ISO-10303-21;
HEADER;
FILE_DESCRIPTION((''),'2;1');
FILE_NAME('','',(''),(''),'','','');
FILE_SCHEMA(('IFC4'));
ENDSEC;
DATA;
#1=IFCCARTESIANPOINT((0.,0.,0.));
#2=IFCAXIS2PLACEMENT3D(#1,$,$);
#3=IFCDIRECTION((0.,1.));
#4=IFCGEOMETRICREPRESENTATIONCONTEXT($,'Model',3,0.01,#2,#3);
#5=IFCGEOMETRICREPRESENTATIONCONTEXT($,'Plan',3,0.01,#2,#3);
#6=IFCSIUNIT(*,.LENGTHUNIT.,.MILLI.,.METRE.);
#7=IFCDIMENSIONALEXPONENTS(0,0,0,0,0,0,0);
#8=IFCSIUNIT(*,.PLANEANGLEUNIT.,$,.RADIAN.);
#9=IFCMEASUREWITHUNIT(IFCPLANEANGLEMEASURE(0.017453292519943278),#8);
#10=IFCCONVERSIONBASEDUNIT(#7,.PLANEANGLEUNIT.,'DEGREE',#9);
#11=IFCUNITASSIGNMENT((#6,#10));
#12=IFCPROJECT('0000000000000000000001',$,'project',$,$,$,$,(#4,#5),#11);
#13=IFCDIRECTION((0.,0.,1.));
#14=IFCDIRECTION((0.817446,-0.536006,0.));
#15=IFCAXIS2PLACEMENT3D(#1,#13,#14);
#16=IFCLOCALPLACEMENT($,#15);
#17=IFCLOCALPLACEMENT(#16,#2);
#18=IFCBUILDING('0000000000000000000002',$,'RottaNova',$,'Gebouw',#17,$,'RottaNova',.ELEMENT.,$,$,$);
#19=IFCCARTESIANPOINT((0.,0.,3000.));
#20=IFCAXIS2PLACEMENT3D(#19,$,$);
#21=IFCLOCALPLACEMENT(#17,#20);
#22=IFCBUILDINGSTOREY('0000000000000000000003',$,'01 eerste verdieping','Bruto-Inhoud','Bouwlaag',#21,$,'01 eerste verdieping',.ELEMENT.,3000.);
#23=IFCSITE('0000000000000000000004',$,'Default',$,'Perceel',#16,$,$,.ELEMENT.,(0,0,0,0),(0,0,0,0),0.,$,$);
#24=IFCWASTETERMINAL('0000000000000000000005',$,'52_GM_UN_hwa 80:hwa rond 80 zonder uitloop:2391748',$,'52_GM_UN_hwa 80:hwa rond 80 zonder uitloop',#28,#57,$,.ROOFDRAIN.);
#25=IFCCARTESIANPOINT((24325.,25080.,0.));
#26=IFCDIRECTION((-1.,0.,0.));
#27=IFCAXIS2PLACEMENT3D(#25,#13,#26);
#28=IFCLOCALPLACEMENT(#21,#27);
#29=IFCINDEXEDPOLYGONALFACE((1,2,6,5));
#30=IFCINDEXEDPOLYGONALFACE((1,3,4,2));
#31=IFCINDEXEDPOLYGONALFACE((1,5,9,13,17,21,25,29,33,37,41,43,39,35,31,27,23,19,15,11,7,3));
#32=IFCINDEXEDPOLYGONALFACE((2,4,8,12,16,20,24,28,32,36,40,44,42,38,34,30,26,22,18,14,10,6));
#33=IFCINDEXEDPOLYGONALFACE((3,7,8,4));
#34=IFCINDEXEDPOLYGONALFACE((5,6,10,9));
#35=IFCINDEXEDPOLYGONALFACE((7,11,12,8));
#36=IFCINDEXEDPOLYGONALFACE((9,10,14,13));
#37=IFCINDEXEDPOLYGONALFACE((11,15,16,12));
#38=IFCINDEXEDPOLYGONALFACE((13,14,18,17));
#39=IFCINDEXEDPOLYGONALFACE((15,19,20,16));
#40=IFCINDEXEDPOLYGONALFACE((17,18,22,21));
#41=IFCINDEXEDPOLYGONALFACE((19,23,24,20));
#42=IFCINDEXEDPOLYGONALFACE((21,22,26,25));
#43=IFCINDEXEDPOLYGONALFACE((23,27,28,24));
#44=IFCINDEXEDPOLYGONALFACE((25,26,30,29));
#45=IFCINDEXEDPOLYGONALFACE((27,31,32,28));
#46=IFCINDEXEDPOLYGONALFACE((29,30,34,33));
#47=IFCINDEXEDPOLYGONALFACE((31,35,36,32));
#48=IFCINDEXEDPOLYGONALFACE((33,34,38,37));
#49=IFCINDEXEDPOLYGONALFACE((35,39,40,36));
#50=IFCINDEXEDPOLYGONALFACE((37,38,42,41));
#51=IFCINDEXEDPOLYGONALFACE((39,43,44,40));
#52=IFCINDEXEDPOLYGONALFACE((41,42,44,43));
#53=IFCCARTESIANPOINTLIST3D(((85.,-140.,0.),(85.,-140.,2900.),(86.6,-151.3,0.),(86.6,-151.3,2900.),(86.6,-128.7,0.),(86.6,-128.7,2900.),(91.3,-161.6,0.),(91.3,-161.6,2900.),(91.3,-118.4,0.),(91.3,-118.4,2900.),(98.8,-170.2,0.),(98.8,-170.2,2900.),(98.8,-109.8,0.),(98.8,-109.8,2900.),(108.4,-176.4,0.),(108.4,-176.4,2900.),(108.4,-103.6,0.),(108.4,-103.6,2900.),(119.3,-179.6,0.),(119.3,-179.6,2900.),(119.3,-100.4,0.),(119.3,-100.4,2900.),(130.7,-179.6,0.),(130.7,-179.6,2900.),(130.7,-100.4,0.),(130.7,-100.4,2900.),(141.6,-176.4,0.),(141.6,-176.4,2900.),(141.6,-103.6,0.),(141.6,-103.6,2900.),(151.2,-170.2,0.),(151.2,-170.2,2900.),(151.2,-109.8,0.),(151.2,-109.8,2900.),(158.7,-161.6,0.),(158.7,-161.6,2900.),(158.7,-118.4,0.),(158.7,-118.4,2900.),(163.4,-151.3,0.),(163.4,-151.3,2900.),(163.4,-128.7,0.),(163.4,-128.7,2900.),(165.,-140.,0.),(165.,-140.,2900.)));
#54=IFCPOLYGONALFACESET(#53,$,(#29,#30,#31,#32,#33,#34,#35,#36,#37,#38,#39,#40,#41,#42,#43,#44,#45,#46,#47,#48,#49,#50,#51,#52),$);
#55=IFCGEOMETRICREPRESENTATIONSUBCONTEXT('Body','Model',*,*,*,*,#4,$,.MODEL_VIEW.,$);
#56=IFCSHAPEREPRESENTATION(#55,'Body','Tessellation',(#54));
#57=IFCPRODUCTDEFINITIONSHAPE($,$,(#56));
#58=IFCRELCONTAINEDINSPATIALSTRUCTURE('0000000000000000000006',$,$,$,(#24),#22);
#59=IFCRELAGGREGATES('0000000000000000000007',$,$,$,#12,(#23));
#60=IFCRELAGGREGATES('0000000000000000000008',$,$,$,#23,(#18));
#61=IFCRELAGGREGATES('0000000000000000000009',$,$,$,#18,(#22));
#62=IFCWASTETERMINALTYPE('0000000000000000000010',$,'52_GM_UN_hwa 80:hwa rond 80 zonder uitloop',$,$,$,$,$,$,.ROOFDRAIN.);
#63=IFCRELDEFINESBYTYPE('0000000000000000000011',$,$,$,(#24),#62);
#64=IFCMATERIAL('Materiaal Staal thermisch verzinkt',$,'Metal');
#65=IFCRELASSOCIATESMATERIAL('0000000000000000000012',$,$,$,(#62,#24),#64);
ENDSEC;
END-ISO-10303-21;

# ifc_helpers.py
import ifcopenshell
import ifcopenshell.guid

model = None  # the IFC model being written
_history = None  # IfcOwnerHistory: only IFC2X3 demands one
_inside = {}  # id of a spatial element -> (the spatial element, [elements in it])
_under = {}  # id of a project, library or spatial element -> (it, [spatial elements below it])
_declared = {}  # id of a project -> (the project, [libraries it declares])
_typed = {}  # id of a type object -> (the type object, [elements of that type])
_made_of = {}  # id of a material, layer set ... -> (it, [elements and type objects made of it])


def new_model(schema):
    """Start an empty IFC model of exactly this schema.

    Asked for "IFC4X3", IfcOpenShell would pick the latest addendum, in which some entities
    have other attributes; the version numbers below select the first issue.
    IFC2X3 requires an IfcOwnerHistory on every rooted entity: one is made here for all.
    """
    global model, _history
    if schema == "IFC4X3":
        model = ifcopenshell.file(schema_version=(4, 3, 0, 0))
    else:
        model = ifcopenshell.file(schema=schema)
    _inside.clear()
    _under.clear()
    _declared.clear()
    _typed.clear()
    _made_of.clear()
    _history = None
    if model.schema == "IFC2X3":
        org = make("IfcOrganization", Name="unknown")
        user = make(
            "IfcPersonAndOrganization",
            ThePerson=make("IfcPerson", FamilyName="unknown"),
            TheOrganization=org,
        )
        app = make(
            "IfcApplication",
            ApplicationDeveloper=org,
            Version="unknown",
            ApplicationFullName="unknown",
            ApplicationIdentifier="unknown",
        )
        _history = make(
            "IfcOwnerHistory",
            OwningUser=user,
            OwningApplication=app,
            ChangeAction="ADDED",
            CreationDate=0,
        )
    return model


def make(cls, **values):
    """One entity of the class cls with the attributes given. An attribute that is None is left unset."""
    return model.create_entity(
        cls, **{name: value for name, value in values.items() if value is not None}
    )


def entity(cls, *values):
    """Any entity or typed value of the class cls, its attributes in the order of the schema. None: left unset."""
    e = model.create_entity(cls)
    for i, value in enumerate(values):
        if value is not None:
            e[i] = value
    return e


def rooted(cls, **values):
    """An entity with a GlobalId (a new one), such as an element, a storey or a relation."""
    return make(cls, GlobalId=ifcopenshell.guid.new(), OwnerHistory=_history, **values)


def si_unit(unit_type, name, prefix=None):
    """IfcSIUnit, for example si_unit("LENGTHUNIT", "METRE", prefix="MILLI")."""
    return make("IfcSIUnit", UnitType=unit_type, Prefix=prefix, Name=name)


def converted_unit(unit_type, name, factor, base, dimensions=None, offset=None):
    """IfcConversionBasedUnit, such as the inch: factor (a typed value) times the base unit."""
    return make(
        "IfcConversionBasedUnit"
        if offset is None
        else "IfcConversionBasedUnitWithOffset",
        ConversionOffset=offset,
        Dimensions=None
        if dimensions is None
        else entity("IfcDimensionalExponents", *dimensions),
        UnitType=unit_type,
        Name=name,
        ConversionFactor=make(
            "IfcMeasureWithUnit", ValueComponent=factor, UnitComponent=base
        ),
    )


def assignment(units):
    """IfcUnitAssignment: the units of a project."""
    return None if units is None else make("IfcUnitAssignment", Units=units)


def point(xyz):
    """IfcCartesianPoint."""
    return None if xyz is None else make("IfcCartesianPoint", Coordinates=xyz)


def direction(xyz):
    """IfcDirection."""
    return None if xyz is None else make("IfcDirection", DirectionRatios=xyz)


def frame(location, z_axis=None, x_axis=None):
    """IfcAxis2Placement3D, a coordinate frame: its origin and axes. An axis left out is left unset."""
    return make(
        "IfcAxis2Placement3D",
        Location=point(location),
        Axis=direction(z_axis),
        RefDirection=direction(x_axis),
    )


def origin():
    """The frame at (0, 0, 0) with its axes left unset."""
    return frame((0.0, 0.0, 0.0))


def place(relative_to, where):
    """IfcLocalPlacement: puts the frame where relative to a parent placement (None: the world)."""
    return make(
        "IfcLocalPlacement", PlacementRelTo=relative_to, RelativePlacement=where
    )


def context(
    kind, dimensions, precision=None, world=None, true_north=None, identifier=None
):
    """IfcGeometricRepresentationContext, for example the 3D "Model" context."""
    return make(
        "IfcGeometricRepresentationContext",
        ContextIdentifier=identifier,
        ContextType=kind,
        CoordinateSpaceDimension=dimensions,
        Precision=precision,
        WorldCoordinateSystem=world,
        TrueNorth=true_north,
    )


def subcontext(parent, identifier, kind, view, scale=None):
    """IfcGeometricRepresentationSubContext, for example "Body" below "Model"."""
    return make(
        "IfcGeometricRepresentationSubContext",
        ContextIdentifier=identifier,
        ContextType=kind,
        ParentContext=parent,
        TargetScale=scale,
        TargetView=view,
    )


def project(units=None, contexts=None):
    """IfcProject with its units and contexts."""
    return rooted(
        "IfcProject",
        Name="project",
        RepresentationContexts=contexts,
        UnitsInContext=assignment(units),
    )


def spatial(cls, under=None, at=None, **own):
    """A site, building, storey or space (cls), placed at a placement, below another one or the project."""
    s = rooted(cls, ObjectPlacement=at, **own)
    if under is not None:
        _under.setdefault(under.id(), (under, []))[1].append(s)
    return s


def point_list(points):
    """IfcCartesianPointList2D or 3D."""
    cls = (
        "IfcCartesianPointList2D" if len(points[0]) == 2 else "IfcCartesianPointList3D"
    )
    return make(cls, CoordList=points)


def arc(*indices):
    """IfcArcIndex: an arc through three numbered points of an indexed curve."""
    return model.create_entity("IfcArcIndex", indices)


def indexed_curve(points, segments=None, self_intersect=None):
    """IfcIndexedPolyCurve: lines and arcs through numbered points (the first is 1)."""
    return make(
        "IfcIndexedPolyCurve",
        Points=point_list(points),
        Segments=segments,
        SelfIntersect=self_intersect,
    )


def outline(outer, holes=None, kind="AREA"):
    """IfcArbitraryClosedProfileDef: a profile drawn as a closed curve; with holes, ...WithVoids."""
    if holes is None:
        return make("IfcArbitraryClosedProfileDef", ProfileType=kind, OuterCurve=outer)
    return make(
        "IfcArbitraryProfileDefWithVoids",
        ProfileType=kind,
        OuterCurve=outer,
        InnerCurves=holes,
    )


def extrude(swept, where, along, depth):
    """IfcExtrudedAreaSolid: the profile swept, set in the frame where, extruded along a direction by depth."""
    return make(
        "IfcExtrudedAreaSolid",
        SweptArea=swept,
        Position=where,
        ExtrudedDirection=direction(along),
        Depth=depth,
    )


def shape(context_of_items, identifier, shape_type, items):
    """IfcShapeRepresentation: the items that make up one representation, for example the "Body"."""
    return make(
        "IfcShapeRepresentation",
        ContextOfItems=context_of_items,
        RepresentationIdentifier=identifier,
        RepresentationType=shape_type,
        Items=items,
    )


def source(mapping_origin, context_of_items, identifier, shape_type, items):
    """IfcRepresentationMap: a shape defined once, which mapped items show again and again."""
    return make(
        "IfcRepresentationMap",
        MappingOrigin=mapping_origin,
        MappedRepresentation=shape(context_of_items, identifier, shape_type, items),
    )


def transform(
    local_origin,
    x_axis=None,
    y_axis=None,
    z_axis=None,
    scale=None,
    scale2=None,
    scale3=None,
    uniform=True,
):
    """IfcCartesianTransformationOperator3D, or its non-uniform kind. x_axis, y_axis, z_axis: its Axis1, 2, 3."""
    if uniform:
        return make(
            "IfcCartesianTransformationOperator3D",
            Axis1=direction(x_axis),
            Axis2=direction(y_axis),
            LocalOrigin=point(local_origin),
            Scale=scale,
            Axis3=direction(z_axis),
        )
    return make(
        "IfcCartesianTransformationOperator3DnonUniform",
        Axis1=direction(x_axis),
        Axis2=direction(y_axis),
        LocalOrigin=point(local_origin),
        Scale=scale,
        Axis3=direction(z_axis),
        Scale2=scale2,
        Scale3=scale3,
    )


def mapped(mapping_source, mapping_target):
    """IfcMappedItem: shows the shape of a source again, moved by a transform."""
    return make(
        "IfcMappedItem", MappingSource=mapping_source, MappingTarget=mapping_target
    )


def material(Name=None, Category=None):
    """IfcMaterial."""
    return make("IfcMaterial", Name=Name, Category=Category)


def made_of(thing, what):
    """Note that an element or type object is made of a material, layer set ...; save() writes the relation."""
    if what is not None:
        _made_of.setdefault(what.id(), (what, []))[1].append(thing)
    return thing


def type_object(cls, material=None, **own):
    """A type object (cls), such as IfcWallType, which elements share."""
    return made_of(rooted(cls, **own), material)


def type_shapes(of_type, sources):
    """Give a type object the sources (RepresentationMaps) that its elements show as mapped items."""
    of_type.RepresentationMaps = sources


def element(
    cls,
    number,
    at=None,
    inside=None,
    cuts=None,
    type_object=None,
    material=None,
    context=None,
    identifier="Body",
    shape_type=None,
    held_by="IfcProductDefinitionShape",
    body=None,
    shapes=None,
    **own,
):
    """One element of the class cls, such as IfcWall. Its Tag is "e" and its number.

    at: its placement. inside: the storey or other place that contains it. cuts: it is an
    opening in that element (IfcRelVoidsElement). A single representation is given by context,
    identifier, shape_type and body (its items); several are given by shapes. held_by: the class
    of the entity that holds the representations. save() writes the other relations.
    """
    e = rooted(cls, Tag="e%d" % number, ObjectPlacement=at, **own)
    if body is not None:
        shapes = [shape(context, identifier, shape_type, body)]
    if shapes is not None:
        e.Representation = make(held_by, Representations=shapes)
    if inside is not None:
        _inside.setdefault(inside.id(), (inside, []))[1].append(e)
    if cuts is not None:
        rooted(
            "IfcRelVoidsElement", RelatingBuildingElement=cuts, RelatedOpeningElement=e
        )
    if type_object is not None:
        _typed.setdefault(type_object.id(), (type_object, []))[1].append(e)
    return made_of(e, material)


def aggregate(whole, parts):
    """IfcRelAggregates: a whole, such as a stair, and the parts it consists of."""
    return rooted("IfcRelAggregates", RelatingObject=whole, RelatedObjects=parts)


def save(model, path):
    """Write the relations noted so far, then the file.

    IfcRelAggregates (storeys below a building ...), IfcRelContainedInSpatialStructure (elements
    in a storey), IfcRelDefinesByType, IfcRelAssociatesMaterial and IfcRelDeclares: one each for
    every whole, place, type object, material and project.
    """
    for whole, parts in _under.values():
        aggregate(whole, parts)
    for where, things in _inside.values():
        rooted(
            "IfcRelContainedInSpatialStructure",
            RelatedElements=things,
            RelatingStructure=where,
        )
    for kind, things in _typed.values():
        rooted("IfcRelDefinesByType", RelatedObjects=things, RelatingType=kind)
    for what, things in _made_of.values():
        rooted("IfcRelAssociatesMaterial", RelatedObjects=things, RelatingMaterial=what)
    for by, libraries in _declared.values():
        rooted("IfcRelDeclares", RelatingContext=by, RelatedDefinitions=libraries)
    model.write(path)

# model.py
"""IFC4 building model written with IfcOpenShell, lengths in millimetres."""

from ifc_helpers import new_model, entity, si_unit, converted_unit, direction, frame, origin, place, context, subcontext, project, spatial, arc, indexed_curve, outline, extrude, source, transform, mapped, material, type_object, type_shapes, element, save


model = new_model("IFC4")

# Units and contexts
model_context = context("Model", 3, precision=0.01, world=origin(), true_north=direction((0.0, 1.0)))
plan_context = context("Plan", 3, precision=0.01, world=origin(), true_north=direction((0.0, 1.0)))
body_context = subcontext(model_context, "Body", "Model", "MODEL_VIEW")
ifc_project = project(units=[si_unit("LENGTHUNIT", "METRE", prefix="MILLI"), converted_unit("PLANEANGLEUNIT", "DEGREE", entity("IfcPlaneAngleMeasure", 0.017453292519943278), si_unit("PLANEANGLEUNIT", "RADIAN"), dimensions=[0, 0, 0, 0, 0, 0, 0])], contexts=[model_context, plan_context])

# Site, building, storey
site_placement = place(None, frame((0.0, 0.0, 0.0), z_axis=(0.0, 0.0, 1.0), x_axis=(0.817446, -0.536006, 0.0)))
site = spatial("IfcSite", under=ifc_project, at=site_placement, Name="Default", ObjectType="Perceel", CompositionType="ELEMENT", RefLatitude=(0, 0, 0, 0), RefLongitude=(0, 0, 0, 0), RefElevation=0.0)
building_placement = place(site_placement, origin())
building = spatial("IfcBuilding", under=site, at=building_placement, Name="RottaNova", ObjectType="Gebouw", LongName="RottaNova", CompositionType="ELEMENT")
storey_placement = place(building_placement, frame((0.0, 0.0, 3000.0)))
storey = spatial("IfcBuildingStorey", under=building, at=storey_placement, Name="01 eerste verdieping", Description="Bruto-Inhoud", ObjectType="Bouwlaag", LongName="01 eerste verdieping", CompositionType="ELEMENT", Elevation=3000.0)

# Waste terminal
ifc_material_1 = material(Name="Materiaal Staal thermisch verzinkt", Category="Metal")
waste_terminal_type = type_object("IfcWasteTerminalType", Name="52_GM_UN_hwa 80:hwa rond 80 zonder uitloop", PredefinedType="ROOFDRAIN", material=ifc_material_1)
shared_shape_1 = source(origin(), body_context, "Body", "SweptSolid", [
    extrude(outline(indexed_curve([(-40.0, 0.0), (0.0, -40.0), (40.0, 0.0), (0.0, 40.0)], segments=[arc(1, 2, 3), arc(3, 4, 1)], self_intersect=False)), frame((125.0, -140.0, 0.0)), (0.0, 0.0, 1.0), 2900.0),
])
type_shapes(waste_terminal_type, [shared_shape_1])
waste_terminal_placement = place(storey_placement, frame((24325.0, 25080.0, 0.0), z_axis=(0.0, 0.0, 1.0), x_axis=(-1.0, 0.0, 0.0)))
element("IfcWasteTerminal", 1, at=waste_terminal_placement, inside=storey, type_object=waste_terminal_type, material=ifc_material_1, Name="52_GM_UN_hwa 80:hwa rond 80 zonder uitloop:2391748", ObjectType="52_GM_UN_hwa 80:hwa rond 80 zonder uitloop", PredefinedType="ROOFDRAIN", context=body_context, shape_type="MappedRepresentation", body=[
    mapped(shared_shape_1, transform((0.0, 0.0, 0.0), scale=1.0)),
])

save(model, "model.ifc")
